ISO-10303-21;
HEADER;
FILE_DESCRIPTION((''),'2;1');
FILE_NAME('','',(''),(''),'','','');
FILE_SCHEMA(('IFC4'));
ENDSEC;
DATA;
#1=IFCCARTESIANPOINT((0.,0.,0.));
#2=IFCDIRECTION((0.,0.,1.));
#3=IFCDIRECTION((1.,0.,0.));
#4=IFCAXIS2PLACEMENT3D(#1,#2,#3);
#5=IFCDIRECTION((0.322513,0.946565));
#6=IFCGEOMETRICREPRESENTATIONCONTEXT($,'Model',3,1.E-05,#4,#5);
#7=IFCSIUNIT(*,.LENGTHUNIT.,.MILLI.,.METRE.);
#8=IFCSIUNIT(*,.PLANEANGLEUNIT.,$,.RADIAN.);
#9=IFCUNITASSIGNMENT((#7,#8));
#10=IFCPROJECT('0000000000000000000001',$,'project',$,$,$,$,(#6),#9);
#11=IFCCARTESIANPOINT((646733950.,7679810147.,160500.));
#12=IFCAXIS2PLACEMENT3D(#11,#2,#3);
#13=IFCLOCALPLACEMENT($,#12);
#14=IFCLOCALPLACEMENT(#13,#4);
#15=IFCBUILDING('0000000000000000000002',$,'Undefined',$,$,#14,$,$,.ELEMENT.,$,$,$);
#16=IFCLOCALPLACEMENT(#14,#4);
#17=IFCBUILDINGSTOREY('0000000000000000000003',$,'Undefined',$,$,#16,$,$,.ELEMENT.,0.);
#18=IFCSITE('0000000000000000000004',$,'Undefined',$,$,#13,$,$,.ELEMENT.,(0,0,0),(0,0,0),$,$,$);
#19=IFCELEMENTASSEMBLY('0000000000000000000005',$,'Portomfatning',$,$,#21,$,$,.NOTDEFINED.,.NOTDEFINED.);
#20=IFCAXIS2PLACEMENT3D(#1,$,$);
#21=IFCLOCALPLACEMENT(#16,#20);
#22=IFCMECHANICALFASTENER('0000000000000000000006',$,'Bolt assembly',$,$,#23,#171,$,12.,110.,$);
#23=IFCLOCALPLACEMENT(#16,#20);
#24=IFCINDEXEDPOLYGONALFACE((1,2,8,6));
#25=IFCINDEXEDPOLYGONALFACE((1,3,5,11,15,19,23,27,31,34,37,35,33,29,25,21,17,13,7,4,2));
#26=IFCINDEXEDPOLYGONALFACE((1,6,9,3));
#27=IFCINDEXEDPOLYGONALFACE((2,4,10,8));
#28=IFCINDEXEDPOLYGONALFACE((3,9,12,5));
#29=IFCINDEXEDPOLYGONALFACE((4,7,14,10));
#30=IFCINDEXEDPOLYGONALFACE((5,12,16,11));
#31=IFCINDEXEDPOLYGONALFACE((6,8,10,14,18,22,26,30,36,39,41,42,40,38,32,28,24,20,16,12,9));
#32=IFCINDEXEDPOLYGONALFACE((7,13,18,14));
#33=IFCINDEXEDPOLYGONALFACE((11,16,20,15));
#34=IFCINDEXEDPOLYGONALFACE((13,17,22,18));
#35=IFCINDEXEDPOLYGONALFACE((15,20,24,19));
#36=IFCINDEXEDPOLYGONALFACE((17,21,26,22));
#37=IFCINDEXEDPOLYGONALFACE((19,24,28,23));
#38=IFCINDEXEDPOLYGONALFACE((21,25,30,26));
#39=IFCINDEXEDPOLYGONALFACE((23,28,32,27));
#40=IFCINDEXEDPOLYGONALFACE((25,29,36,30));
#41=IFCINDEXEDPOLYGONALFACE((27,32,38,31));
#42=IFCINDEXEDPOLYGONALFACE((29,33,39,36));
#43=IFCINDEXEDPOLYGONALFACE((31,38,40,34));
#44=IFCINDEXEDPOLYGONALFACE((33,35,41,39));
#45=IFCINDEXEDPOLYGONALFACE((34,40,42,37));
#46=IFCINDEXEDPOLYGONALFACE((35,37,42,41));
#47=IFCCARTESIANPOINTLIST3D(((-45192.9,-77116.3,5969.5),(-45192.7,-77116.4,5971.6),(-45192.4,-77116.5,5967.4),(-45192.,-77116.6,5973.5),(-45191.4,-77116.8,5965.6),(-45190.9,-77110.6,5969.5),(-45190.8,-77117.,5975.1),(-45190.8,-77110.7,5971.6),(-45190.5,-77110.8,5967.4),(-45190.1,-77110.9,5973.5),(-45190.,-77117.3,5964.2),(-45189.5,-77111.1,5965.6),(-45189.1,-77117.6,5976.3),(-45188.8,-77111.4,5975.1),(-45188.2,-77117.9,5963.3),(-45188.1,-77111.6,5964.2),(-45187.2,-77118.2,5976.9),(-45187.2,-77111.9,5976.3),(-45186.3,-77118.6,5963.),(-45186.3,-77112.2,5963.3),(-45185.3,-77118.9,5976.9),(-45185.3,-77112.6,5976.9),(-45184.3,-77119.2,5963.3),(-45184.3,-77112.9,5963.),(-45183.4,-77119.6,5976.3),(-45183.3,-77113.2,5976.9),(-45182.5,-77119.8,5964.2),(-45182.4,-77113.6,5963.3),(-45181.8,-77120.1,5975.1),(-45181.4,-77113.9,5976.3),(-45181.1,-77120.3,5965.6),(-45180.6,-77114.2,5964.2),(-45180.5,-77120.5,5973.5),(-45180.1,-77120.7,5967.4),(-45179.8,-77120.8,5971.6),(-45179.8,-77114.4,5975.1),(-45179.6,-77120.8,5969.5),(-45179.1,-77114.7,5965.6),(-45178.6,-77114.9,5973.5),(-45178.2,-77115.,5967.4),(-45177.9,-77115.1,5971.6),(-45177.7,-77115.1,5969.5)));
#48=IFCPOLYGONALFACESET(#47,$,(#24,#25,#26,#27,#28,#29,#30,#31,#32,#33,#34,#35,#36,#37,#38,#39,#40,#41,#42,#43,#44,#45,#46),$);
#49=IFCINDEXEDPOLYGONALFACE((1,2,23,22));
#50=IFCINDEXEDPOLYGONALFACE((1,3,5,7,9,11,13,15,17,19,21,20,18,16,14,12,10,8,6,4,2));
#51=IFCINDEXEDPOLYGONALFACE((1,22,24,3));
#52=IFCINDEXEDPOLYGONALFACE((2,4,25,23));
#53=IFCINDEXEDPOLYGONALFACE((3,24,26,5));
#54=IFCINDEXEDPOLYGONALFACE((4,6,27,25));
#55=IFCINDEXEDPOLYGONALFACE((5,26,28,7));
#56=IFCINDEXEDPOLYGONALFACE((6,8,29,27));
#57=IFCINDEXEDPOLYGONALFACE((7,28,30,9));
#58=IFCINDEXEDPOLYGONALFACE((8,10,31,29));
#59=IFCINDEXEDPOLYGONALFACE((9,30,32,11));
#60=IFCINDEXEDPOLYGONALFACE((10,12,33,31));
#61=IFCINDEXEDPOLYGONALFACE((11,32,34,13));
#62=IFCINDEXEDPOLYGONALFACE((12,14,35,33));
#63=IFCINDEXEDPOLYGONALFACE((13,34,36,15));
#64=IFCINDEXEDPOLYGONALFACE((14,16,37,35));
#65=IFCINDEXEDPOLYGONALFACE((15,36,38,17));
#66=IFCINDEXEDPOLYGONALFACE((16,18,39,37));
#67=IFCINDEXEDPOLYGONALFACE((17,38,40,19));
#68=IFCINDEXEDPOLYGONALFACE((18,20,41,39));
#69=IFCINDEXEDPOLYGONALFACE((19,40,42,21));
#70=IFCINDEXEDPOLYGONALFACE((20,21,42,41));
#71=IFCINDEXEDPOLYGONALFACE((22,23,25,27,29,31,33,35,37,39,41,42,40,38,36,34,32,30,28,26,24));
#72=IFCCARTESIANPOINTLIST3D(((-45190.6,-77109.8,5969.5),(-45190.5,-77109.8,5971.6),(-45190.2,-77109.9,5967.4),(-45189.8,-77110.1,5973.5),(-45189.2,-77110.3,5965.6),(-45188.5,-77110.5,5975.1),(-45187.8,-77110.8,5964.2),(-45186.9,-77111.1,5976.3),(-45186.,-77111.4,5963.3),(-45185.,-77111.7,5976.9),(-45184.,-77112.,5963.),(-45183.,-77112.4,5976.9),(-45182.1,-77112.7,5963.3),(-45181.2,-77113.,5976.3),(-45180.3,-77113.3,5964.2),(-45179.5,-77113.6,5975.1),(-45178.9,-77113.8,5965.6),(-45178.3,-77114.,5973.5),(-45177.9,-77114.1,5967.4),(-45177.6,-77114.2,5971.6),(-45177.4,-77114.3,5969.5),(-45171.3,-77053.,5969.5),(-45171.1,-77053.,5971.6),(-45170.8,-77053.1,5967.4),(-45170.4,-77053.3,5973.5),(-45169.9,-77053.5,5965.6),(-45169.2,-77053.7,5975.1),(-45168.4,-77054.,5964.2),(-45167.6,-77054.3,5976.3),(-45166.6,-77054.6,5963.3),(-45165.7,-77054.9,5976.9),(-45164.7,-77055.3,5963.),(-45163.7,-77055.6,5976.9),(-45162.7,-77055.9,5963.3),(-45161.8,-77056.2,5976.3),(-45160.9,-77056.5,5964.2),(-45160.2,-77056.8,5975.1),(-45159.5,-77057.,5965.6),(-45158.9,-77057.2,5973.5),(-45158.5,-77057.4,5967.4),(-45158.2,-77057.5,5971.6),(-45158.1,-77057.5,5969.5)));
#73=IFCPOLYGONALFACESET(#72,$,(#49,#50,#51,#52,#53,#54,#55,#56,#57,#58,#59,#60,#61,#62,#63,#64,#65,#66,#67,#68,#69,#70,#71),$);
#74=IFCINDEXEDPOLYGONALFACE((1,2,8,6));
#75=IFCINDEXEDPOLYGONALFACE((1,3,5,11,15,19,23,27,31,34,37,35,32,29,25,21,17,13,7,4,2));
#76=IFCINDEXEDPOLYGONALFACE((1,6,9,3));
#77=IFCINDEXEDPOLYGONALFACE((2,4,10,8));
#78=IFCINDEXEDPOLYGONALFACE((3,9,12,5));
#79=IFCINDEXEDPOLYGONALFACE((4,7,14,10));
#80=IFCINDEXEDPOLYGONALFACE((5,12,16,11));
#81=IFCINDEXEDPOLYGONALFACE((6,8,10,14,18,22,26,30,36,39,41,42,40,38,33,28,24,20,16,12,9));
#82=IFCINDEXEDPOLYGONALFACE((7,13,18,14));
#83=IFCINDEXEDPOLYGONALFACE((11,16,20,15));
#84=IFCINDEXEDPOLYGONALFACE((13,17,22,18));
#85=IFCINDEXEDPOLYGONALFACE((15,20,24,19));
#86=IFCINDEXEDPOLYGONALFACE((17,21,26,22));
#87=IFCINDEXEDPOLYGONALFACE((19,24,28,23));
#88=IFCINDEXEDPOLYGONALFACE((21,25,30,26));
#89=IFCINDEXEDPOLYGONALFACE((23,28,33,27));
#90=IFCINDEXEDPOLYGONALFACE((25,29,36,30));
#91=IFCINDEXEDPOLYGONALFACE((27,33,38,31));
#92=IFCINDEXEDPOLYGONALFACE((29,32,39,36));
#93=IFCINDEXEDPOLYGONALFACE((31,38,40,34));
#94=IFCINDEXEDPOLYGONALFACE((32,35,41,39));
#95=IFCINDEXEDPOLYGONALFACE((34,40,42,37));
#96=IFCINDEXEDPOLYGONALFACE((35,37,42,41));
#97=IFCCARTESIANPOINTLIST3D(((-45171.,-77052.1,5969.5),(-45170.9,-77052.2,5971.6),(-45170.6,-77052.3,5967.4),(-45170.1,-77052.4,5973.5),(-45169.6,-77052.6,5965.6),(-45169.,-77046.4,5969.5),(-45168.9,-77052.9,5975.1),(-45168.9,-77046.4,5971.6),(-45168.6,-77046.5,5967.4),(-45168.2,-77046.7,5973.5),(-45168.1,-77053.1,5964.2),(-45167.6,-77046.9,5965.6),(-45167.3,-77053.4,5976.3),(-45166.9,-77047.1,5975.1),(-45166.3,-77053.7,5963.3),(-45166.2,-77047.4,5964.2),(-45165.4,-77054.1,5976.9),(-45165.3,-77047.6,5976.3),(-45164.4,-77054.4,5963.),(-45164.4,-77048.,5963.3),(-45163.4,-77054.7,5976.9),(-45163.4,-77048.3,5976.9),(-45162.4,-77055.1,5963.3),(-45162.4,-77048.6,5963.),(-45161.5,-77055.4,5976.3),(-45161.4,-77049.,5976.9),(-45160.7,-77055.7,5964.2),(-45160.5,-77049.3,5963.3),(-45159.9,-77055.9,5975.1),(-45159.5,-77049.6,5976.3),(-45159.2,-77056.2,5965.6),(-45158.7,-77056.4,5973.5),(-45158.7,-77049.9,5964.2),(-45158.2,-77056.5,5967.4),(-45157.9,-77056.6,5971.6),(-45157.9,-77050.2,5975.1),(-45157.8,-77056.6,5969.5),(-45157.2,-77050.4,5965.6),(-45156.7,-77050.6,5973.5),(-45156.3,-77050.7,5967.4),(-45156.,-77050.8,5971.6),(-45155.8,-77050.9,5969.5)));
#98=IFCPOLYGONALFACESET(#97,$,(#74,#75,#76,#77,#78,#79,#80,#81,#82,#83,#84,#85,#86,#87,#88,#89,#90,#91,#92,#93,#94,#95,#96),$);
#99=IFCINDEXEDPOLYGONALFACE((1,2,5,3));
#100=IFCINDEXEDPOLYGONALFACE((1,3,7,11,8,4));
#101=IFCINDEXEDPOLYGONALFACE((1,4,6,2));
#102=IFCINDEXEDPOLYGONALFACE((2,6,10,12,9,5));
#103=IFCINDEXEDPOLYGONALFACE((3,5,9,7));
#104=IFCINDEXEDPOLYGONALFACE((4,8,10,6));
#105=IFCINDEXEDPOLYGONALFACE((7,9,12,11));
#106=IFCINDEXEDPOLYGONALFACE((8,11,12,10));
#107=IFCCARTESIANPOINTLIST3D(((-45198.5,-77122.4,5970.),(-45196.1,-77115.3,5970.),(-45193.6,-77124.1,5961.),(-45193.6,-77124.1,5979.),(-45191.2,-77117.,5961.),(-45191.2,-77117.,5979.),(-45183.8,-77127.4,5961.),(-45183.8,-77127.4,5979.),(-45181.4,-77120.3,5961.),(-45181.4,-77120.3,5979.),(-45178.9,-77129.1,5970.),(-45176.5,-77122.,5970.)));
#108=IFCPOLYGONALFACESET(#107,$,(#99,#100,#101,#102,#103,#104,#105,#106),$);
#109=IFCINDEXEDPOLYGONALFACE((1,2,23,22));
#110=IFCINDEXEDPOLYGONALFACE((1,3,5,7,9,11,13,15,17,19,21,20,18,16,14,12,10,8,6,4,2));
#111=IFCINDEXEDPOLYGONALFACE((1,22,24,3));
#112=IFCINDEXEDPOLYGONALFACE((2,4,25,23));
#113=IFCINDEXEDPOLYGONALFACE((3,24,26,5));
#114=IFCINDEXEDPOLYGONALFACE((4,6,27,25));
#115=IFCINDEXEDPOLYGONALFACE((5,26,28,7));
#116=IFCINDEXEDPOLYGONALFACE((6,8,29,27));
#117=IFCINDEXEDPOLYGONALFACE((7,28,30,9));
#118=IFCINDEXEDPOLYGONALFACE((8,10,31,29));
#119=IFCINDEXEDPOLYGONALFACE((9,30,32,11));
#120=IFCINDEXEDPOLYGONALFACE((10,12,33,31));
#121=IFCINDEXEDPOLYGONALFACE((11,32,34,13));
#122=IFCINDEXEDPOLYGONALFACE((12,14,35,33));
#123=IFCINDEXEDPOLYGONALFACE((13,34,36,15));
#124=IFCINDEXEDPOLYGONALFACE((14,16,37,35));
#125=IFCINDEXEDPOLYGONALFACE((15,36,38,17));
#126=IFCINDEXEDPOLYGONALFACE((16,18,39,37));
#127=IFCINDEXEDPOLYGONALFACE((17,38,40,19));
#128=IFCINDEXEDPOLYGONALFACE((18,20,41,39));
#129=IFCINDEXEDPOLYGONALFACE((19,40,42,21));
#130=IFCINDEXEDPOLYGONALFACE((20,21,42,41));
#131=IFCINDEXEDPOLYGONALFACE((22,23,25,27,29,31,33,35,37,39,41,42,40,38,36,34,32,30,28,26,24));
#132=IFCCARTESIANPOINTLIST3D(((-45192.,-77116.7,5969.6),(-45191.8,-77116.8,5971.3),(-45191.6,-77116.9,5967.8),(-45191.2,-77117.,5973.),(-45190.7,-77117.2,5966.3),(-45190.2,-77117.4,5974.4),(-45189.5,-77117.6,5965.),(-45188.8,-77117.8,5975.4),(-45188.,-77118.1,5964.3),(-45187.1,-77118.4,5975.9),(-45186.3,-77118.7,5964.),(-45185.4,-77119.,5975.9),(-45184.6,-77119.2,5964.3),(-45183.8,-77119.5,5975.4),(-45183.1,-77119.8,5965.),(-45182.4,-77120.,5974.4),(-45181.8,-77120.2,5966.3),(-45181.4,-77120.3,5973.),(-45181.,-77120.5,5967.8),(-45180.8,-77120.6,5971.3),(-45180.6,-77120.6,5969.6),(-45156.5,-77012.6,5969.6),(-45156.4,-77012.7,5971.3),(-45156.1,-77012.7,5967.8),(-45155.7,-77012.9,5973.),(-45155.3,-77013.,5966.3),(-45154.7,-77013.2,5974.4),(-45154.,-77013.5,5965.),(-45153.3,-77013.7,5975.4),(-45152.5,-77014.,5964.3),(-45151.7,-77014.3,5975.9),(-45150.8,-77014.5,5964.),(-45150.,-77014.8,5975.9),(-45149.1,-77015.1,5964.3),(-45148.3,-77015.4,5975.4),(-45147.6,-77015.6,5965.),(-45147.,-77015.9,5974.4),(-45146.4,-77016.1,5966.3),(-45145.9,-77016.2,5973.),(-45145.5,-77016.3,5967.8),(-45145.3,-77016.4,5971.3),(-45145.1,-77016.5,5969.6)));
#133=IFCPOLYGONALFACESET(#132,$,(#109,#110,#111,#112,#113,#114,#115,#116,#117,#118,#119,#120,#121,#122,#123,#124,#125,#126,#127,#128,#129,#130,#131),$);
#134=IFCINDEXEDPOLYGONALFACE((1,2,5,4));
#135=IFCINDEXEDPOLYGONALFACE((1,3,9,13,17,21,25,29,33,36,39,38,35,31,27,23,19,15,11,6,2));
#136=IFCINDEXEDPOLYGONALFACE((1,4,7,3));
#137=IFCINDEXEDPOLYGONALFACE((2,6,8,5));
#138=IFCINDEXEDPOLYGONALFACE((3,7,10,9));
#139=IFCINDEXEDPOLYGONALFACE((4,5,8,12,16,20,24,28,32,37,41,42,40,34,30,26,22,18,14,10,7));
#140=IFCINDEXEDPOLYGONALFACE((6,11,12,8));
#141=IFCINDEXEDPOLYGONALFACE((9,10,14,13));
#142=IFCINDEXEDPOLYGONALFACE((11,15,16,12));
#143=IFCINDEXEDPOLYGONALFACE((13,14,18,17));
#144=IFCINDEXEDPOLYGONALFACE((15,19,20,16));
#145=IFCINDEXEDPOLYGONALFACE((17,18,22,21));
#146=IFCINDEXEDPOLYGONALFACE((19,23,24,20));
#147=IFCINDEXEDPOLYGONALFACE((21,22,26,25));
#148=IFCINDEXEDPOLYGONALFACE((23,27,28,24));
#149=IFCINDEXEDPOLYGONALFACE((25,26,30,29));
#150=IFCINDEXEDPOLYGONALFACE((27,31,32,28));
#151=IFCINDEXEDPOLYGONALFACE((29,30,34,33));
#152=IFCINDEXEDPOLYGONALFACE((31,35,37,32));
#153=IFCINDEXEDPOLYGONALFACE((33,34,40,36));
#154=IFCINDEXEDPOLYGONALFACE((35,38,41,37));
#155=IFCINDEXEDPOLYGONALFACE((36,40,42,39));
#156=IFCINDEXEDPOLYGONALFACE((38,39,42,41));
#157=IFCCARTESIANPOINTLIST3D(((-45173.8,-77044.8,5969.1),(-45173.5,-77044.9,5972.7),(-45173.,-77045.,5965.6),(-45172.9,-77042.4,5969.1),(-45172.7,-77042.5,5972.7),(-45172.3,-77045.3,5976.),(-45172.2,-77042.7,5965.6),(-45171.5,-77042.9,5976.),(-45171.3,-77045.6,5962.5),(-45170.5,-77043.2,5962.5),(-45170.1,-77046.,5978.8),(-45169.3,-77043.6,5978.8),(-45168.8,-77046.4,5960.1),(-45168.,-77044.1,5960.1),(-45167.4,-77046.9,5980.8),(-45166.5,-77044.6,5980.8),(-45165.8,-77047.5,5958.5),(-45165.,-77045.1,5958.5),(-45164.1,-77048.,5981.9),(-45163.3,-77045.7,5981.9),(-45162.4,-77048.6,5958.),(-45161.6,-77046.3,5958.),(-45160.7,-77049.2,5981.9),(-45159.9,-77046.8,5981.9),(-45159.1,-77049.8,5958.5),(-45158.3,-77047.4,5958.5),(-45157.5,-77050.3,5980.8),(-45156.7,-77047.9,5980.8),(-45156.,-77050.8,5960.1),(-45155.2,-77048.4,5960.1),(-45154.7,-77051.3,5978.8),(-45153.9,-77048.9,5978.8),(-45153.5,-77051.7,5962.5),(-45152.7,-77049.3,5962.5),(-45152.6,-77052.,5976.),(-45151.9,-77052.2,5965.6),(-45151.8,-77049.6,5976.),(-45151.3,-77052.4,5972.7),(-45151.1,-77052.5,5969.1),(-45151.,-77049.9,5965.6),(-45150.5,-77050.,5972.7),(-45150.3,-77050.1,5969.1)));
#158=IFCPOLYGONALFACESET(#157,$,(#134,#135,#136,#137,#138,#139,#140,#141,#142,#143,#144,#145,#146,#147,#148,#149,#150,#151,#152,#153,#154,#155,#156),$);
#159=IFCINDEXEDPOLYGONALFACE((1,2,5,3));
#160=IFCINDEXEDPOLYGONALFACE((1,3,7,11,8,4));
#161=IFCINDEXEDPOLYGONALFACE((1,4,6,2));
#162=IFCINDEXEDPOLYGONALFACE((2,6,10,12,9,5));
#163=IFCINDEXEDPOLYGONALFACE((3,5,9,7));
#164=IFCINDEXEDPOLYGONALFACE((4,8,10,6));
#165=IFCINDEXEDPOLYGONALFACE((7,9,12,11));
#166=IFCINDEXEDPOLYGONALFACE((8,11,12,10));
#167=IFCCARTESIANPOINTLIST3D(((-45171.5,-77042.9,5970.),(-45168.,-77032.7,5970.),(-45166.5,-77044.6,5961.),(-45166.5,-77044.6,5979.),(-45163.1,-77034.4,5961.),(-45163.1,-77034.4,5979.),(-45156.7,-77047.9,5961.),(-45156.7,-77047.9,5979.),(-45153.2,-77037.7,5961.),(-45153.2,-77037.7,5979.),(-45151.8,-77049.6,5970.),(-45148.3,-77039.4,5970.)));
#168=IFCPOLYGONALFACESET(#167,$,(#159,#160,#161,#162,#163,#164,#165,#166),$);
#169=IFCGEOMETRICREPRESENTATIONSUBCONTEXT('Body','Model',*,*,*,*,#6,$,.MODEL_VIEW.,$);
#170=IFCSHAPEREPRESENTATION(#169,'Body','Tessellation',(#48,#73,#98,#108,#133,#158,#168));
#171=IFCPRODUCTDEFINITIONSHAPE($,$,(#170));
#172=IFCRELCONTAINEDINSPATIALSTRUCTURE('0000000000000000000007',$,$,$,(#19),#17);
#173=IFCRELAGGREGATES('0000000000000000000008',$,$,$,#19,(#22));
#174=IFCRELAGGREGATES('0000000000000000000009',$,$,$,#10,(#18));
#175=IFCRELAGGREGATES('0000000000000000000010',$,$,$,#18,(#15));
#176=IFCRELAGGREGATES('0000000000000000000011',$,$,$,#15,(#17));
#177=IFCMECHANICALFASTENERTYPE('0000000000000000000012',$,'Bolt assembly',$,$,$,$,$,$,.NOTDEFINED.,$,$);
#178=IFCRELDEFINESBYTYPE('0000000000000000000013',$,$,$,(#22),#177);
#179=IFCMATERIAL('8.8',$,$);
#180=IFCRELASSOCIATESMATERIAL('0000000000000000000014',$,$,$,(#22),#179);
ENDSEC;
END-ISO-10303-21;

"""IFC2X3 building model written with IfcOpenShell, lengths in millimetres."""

from ifc_helpers import new_model, si_unit, direction, frame, origin_with_axes, origin_2d_with_axis, place, context, subcontext, project, spatial, polyline, circle, outline, extrude, source, transform, mapped, material, type_object, element, aggregate, save


model = new_model("IFC2X3")

# Units and contexts
model_context = context("Model", 3, precision=1e-05, world=origin_with_axes(), true_north=direction((0.322513, 0.946565)))
body_context = subcontext(model_context, "Body", "Model", "MODEL_VIEW")
ifc_project = project(units=[si_unit("LENGTHUNIT", "METRE", prefix="MILLI"), si_unit("PLANEANGLEUNIT", "RADIAN")], contexts=[model_context])

# Site, building, storey
site_placement = place(None, frame((646733950.0, 7679810147.0, 160500.0), z_axis=(0.0, 0.0, 1.0), x_axis=(1.0, 0.0, 0.0)))
site = spatial("IfcSite", under=ifc_project, at=site_placement, Name="Undefined", CompositionType="ELEMENT", RefLatitude=(0, 0, 0), RefLongitude=(0, 0, 0))
building_placement = place(site_placement, origin_with_axes())
building = spatial("IfcBuilding", under=site, at=building_placement, Name="Undefined", CompositionType="ELEMENT")
storey_placement = place(building_placement, origin_with_axes())
storey = spatial("IfcBuildingStorey", under=building, at=storey_placement, Name="Undefined", CompositionType="ELEMENT", Elevation=0.0)

# Element assembly
assembly_1_placement = place(storey_placement, origin_with_axes())
assembly_1 = element("IfcElementAssembly", 1, at=assembly_1_placement, inside=storey, Name="Portomfatning", AssemblyPlace="NOTDEFINED", PredefinedType="NOTDEFINED")

# Shared definitions
ifc_material_1 = material(Name="8.8")
mechanical_fastener_type = type_object("IfcMechanicalFastenerType", Name="Bolt assembly")

# Mechanical fastener
shared_shape_1 = source(origin_with_axes(), body_context, "Body", "SweptSolid", [
    extrude(circle(Radius=7.0, at=origin_2d_with_axis()), frame((0.0, 0.1, 0.0), z_axis=(0.0, 1.0, 0.0), x_axis=(1.0, 0.0, 0.0)), (0.0, 0.0, 1.0), 6.0),
    extrude(circle(Radius=7.0, at=origin_2d_with_axis()), frame((0.0, 7.0, 0.0), z_axis=(0.0, 1.0, 0.0), x_axis=(1.0, 0.0, 0.0)), (0.0, 0.0, 1.0), 60.0),
    extrude(circle(Radius=7.0, at=origin_2d_with_axis()), frame((0.0, 67.9, 0.0), z_axis=(0.0, 1.0, 0.0), x_axis=(1.0, 0.0, 0.0)), (0.0, 0.0, 1.0), 6.1),
    extrude(outline(polyline([(9.0, -5.2), (9.0, 5.2), (0.0, 10.4), (-9.0, 5.2), (-9.0, -5.2), (0.0, -10.4), (9.0, -5.2)])), frame((0.0, -7.5, 0.0), z_axis=(0.0, 1.0, 0.0), x_axis=(1.0, 0.0, 0.0)), (0.0, 0.0, 1.0), 7.5),
    extrude(circle(Radius=6.0, at=origin_2d_with_axis()), frame((0.0, 0.0, 0.0), z_axis=(0.0, 1.0, 0.0), x_axis=(1.0, 0.0, 0.0)), (0.0, 0.0, 1.0), 110.0),
    extrude(circle(Radius=12.0, at=origin_2d_with_axis()), frame((0.0, 74.0, 0.0), z_axis=(0.0, 1.0, 0.0), x_axis=(1.0, 0.0, 0.0)), (0.0, 0.0, 1.0), 2.5),
    extrude(outline(polyline([(9.0, -5.2), (9.0, 5.2), (0.0, 10.4), (-9.0, 5.2), (-9.0, -5.2), (0.0, -10.4), (9.0, -5.2)])), frame((0.0, 76.5, 0.0), z_axis=(0.0, 1.0, 0.0), x_axis=(1.0, 0.0, 0.0)), (0.0, 0.0, 1.0), 10.8),
])
mechanical_fastener_1_placement = place(assembly_1_placement, frame((-45186.3, -77118.7, 5970.0), z_axis=(0.946565, -0.322513, 0.0), x_axis=(0.0, 0.0, -1.0)))
mechanical_fastener_1 = element("IfcMechanicalFastener", 2, at=mechanical_fastener_1_placement, type_object=mechanical_fastener_type, material=ifc_material_1, Name="Bolt assembly", NominalDiameter=12.0, NominalLength=110.0, context=body_context, shape_type="MappedRepresentation", body=[
    mapped(shared_shape_1, transform((0.0, 0.0, 0.0))),
])
aggregate(assembly_1, [mechanical_fastener_1])

save(model, "model.ifc")
